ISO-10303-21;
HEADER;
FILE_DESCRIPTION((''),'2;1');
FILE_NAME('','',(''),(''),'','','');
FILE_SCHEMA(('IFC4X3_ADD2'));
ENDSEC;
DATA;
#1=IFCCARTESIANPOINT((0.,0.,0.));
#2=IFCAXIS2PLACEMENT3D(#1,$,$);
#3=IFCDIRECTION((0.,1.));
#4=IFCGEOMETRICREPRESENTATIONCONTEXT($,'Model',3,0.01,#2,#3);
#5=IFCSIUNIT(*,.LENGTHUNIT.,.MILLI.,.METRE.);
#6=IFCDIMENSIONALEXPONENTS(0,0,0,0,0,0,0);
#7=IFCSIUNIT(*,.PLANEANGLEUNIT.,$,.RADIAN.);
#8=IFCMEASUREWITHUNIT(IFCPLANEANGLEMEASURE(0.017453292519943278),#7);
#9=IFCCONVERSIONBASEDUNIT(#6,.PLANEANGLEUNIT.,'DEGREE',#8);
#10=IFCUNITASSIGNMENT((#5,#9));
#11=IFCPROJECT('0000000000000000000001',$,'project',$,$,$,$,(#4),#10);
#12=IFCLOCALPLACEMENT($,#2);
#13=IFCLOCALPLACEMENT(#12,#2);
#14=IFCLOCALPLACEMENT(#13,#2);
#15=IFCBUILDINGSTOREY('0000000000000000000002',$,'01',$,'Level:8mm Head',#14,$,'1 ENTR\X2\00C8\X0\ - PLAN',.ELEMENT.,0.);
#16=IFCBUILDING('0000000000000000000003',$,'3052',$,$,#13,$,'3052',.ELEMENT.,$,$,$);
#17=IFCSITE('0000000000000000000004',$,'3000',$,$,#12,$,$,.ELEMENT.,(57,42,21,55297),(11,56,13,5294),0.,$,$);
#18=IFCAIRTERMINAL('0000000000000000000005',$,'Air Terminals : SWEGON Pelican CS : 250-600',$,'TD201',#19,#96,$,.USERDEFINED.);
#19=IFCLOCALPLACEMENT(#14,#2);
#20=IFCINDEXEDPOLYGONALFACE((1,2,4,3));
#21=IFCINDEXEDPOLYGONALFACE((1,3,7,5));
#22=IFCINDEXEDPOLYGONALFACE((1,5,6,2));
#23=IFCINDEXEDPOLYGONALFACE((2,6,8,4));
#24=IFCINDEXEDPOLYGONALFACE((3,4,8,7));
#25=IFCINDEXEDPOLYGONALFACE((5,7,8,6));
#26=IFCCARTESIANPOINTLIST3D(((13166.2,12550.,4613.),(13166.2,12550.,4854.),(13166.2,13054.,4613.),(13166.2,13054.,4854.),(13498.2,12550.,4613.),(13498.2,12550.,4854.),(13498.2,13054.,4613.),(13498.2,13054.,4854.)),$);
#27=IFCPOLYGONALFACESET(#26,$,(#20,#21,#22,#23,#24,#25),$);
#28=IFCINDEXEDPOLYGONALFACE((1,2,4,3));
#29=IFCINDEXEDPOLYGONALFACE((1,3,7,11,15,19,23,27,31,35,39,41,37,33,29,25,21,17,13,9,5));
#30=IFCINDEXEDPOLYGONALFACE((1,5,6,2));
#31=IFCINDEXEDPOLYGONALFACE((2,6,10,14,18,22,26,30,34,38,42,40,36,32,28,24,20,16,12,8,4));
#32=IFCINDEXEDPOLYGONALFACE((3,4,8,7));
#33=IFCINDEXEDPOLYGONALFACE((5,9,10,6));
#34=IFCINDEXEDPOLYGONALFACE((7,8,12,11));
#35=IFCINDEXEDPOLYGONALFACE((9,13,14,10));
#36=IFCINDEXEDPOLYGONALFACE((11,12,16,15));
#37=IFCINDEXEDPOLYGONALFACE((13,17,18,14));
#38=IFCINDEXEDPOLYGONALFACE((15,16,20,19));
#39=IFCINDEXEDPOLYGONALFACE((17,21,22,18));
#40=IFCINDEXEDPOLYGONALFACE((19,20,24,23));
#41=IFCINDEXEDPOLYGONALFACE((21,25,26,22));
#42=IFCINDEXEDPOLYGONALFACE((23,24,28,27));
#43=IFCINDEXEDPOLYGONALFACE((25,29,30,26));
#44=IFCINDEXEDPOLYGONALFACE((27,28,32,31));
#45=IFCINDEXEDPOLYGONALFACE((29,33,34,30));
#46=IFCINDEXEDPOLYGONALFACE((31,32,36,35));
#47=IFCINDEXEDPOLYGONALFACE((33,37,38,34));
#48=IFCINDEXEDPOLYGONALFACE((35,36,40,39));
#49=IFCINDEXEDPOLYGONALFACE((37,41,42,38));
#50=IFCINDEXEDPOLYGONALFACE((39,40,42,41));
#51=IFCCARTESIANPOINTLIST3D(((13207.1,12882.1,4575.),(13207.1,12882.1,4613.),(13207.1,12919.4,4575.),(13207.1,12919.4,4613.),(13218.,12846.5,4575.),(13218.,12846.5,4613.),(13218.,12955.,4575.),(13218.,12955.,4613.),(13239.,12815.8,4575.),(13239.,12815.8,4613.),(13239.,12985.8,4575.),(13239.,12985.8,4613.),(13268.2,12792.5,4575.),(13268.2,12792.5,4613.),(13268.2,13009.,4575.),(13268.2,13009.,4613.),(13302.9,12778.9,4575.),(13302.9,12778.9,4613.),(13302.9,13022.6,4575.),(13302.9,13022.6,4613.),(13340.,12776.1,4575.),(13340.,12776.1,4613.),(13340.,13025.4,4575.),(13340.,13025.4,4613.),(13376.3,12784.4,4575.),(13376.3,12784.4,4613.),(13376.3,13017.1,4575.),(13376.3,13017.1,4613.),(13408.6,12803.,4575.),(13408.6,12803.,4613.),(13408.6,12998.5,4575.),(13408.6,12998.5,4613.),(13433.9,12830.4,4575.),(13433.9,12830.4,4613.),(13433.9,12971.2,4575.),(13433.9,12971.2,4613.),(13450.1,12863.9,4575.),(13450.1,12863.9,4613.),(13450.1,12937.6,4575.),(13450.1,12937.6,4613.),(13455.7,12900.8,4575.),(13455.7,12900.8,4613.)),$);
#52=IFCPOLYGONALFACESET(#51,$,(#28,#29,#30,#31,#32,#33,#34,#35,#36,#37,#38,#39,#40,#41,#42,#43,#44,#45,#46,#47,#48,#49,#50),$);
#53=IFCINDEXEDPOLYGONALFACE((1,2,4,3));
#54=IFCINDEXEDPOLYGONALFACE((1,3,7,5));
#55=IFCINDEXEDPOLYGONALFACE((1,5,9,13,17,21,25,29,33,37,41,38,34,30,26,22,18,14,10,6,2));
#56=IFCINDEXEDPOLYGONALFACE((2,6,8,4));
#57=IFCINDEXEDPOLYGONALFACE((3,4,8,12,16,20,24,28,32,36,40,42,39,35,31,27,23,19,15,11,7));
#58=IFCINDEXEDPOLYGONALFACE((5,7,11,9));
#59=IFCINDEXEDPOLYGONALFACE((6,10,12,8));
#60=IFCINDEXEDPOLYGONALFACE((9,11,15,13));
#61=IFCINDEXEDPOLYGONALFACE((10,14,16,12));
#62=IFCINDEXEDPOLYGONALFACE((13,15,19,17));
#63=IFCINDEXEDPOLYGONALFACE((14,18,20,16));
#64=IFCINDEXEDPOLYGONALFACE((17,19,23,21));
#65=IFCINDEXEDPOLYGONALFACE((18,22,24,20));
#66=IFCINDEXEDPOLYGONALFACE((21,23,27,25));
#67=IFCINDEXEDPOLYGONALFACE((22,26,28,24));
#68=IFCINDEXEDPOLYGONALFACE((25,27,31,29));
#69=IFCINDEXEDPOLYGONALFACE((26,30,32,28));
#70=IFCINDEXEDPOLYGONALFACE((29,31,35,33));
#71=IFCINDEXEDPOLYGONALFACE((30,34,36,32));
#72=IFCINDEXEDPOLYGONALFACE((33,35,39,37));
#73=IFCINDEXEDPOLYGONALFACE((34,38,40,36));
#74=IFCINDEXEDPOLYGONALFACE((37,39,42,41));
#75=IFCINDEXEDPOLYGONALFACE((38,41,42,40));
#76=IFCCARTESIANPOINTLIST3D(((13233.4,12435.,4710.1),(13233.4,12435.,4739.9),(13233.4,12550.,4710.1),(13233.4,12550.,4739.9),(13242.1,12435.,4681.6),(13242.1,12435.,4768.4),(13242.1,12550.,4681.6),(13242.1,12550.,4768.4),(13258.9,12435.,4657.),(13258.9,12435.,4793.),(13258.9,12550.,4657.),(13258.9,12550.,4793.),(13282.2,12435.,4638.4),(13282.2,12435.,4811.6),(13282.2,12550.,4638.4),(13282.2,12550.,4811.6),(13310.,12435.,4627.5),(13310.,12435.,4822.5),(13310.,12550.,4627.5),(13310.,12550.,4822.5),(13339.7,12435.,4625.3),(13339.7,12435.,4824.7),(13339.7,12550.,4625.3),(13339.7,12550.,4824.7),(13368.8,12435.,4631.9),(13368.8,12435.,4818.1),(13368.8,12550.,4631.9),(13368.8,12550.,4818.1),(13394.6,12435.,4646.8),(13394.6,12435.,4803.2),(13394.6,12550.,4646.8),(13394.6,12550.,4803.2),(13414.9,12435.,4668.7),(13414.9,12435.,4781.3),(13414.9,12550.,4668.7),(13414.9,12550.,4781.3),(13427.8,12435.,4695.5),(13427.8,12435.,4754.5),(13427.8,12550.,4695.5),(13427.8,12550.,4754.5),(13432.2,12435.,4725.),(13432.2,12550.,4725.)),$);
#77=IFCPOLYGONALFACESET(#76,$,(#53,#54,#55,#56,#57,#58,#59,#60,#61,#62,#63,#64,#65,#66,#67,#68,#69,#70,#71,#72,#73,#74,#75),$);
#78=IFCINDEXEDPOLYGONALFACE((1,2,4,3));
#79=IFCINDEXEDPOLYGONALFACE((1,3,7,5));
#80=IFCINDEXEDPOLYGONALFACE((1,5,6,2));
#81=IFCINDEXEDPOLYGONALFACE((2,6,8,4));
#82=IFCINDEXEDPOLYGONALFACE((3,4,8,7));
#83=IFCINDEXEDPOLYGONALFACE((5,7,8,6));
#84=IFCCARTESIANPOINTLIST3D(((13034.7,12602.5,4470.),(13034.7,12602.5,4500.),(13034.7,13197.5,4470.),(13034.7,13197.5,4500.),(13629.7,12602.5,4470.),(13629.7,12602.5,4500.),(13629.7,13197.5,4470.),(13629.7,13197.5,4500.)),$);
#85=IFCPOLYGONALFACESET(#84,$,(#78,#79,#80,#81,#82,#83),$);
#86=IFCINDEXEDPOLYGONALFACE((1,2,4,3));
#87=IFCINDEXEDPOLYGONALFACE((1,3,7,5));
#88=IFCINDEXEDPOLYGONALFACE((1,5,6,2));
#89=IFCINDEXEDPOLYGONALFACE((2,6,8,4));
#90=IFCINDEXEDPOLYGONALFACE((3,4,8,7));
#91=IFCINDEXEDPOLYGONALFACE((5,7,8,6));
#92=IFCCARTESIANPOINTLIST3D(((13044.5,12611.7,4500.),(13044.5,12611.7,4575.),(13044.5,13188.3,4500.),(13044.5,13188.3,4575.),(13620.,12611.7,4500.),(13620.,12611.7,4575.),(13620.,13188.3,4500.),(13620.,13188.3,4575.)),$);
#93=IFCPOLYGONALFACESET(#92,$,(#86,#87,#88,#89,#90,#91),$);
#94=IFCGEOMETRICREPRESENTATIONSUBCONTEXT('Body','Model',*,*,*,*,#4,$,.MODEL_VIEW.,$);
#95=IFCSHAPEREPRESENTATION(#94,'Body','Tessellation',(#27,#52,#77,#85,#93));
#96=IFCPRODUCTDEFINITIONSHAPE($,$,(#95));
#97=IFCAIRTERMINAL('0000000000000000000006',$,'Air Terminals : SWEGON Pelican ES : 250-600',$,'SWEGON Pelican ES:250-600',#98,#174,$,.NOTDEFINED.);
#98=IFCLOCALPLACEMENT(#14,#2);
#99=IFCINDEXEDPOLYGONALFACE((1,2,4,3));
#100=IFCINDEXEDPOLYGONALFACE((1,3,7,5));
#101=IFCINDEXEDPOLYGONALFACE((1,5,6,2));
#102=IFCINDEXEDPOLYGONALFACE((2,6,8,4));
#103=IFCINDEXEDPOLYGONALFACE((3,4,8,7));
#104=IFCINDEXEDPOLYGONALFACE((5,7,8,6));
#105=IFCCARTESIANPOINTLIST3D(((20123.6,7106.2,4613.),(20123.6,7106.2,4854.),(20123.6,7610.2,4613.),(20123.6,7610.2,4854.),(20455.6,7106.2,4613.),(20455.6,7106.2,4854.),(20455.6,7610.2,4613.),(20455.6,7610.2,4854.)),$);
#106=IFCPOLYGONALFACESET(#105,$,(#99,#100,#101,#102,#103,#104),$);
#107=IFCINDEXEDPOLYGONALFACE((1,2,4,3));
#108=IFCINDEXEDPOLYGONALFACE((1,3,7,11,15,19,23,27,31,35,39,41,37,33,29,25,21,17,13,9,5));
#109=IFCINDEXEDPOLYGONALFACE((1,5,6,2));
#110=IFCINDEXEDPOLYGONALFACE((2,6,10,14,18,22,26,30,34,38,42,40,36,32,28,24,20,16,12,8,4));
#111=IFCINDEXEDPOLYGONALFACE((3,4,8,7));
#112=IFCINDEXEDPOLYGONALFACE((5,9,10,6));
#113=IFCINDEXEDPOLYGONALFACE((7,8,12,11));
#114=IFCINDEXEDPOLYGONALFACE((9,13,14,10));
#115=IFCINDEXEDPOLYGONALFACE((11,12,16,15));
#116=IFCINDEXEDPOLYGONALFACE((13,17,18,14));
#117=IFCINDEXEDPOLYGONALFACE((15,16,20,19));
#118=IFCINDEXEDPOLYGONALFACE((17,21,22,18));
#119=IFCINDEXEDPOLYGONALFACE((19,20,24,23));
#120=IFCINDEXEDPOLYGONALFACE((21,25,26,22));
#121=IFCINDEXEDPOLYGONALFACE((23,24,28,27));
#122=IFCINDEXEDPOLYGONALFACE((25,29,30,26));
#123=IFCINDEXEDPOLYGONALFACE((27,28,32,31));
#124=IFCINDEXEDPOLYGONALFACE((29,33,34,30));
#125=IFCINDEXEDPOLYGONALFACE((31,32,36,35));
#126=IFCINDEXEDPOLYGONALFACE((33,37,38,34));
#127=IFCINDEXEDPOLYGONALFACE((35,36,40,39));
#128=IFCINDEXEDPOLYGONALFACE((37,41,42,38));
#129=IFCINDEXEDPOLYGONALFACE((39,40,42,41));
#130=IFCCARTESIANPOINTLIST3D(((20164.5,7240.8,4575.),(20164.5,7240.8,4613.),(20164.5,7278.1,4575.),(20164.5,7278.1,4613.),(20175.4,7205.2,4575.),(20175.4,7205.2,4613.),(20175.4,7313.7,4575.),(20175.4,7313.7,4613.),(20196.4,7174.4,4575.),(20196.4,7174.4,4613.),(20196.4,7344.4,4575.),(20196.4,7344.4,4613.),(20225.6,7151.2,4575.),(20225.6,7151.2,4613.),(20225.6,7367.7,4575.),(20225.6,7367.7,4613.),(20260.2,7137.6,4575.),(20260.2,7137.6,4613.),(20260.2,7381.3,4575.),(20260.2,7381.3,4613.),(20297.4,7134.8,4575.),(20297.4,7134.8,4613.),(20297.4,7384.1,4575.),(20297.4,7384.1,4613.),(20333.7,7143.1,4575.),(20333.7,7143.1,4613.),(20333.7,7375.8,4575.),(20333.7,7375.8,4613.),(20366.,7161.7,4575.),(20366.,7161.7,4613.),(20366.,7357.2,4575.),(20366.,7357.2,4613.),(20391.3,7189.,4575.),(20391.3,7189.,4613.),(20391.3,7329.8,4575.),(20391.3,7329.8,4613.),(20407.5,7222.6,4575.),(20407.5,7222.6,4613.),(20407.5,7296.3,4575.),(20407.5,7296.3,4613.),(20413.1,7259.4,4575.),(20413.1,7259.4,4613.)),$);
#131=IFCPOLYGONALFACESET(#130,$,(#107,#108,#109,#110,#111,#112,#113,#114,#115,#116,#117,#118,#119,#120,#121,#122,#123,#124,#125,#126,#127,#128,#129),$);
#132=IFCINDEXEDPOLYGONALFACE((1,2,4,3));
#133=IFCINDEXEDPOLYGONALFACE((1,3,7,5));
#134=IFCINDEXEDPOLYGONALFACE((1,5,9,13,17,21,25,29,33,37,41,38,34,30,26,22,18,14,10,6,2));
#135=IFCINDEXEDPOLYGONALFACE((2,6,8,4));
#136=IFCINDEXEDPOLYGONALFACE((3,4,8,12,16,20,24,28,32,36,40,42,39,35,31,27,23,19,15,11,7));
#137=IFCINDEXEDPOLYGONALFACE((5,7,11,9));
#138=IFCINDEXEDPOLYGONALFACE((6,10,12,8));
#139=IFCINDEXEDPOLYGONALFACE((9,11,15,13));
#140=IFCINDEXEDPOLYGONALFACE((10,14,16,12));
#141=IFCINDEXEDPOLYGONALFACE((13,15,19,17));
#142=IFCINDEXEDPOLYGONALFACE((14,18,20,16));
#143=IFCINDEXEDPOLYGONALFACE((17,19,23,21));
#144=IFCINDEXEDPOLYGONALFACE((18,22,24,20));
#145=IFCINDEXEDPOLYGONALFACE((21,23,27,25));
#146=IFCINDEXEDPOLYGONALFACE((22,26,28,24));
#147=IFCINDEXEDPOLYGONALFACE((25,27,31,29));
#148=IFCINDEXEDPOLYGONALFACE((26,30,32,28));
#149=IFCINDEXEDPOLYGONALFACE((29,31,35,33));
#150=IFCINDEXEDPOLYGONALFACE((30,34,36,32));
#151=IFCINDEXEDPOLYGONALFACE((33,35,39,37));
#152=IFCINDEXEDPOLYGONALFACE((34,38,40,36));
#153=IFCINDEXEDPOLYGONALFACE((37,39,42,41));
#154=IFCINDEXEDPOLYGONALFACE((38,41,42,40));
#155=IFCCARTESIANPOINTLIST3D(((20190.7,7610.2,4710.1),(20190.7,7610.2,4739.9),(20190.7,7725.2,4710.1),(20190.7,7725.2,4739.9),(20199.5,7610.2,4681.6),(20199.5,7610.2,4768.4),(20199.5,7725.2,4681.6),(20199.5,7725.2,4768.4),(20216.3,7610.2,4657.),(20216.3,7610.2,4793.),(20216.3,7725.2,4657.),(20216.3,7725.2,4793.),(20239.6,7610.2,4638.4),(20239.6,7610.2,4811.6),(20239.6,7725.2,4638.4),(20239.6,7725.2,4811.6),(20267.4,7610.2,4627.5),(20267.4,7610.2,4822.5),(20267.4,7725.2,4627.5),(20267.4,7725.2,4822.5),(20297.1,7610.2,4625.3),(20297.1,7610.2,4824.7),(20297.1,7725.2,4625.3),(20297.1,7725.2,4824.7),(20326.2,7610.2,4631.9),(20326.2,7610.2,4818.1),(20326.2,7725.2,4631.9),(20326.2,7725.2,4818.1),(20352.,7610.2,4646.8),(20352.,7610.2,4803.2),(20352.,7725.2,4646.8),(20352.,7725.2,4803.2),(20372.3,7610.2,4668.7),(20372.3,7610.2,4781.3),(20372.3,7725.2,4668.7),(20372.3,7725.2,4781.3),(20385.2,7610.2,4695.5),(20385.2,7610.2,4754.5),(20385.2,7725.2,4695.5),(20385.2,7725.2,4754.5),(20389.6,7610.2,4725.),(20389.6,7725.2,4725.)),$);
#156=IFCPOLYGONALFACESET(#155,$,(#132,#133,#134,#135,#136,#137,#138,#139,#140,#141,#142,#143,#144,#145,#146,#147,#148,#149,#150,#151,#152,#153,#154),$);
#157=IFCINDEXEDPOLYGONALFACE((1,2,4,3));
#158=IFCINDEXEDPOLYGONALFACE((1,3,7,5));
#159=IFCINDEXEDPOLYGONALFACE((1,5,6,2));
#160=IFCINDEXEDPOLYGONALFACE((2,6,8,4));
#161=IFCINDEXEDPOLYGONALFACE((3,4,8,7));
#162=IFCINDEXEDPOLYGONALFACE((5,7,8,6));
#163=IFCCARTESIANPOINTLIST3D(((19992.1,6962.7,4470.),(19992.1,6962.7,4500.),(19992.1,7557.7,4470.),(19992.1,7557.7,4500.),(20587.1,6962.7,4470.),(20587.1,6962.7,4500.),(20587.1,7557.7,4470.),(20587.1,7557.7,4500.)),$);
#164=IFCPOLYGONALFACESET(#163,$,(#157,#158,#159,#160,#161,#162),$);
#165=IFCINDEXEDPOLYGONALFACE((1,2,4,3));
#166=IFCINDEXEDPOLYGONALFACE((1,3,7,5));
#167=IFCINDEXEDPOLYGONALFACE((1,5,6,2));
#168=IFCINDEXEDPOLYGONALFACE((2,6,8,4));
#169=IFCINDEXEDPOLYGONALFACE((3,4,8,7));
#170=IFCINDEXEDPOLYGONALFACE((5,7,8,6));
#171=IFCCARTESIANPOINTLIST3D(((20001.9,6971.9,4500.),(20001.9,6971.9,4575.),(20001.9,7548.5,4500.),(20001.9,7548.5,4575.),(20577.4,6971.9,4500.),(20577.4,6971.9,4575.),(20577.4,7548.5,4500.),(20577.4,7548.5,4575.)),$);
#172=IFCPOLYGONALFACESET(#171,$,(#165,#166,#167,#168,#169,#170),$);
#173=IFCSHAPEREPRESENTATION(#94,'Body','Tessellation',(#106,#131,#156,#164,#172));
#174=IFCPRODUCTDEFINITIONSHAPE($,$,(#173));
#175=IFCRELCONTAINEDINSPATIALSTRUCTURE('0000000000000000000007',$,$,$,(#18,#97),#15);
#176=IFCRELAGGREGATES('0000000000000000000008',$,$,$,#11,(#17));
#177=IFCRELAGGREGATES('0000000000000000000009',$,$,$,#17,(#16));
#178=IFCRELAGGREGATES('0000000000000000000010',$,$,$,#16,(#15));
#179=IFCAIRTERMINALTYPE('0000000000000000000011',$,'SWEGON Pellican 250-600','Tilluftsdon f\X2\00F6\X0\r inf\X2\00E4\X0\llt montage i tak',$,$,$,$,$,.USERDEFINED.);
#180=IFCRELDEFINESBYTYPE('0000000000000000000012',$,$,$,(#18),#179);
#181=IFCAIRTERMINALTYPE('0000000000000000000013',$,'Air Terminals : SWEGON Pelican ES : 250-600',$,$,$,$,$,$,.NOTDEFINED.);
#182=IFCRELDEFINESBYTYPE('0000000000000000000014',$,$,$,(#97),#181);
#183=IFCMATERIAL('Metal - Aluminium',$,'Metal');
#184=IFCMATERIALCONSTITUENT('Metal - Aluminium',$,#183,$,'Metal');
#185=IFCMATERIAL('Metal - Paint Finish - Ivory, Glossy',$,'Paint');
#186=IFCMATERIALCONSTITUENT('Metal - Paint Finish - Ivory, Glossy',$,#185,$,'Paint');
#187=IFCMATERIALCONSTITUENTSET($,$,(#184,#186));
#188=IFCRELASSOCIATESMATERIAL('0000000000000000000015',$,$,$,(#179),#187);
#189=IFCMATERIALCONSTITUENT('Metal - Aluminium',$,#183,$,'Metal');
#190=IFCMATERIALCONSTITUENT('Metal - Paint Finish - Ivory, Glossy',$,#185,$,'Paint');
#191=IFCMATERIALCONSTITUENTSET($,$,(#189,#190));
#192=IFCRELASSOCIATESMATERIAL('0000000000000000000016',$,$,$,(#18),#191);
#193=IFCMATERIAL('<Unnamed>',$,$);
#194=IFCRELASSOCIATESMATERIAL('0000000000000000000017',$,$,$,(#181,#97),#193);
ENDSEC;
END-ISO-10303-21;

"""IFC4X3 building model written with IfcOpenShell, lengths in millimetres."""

from ifc_helpers import new_model, entity, si_unit, converted_unit, direction, frame, frame_2d, origin, origin_2d_with_axis, place, context, subcontext, project, spatial, rectangle, circle, extrude, source, transform, mapped, material, constituent, constituent_set, type_object, type_shapes, element, save


model = new_model("IFC4X3")

# Units and contexts
model_context = context("Model", 3, precision=0.01, world=origin(), true_north=direction((0.0, 1.0)))
body_context = subcontext(model_context, "Body", "Model", "MODEL_VIEW")
ifc_project = project(units=[si_unit("LENGTHUNIT", "METRE", prefix="MILLI"), converted_unit("PLANEANGLEUNIT", "DEGREE", entity("IfcPlaneAngleMeasure", 0.017453292519943278), si_unit("PLANEANGLEUNIT", "RADIAN"), dimensions=[0, 0, 0, 0, 0, 0, 0])], contexts=[model_context])

# Site, building, storey
site_placement = place(None, origin())
site = spatial("IfcSite", under=ifc_project, at=site_placement, Name="3000", CompositionType="ELEMENT", RefLatitude=(57, 42, 21, 55297), RefLongitude=(11, 56, 13, 5294), RefElevation=0.0)
building_placement = place(site_placement, origin())
building = spatial("IfcBuilding", under=site, at=building_placement, Name="3052", LongName="3052", CompositionType="ELEMENT")
storey_placement = place(building_placement, origin())
storey = spatial("IfcBuildingStorey", under=building, at=storey_placement, Name="01", ObjectType="Level:8mm Head", LongName="1 ENTRÈ - PLAN", CompositionType="ELEMENT", Elevation=0.0)

# Shared definitions
ifc_material_1 = material(Name="Metal - Aluminium", Category="Metal")
ifc_material_2 = material(Name="Metal - Paint Finish - Ivory, Glossy", Category="Paint")
ifc_material_3 = material(Name="<Unnamed>")

# Air terminals
ifc_constituent_1 = constituent(ifc_material_1, Name="Metal - Aluminium", Category="Metal")
ifc_constituent_2 = constituent(ifc_material_2, Name="Metal - Paint Finish - Ivory, Glossy", Category="Paint")
ifc_constituent_set_1 = constituent_set(constituents=[ifc_constituent_1, ifc_constituent_2])
air_terminal_type_1 = type_object("IfcAirTerminalType", Name="SWEGON Pellican 250-600", Description="Tilluftsdon för infällt montage i tak", PredefinedType="USERDEFINED", material=ifc_constituent_set_1)
shared_shape_1 = source(origin(), body_context, "Body", "SweptSolid", [
    extrude(rectangle(XDim=332.0, YDim=504.0, at=origin_2d_with_axis()), frame((0.0, 98.0, -354.0), z_axis=(0.0, 0.0, 1.0), x_axis=(-1.0, 0.0, 0.0)), (0.0, 0.0, 1.0), 241.0),
    extrude(circle(Radius=125.0, at=frame_2d((0.0, 0.0), x_axis=(1.0, 0.0))), frame((-1.6, -0.8, -113.0)), (0.0, 0.0, 1.0), 38.0),
    extrude(circle(Radius=100.0, at=frame_2d((0.0, 0.0), x_axis=(1.0, 0.0))), frame((0.0, 350.0, -225.0), z_axis=(0.0, 1.0, 0.0), x_axis=(1.0, 0.0, 0.0)), (0.0, 0.0, 1.0), 115.0),
    extrude(rectangle(XDim=595.0, YDim=595.0, at=frame_2d((0.0, 0.0), x_axis=(1.0, 0.0))), frame((0.0, 0.0, 0.0), z_axis=(0.0, 0.0, 1.0), x_axis=(-1.0, 0.0, 0.0)), (0.0, 0.0, 1.0), 30.0),
    extrude(rectangle(XDim=575.5, YDim=576.5, at=origin_2d_with_axis()), frame((0.0, 0.0, -75.0), z_axis=(0.0, 0.0, 1.0), x_axis=(-1.0, 0.0, 0.0)), (0.0, 0.0, 1.0), 75.0),
])
type_shapes(air_terminal_type_1, [shared_shape_1])
ifc_constituent_3 = constituent(ifc_material_1, Name="Metal - Aluminium", Category="Metal")
ifc_constituent_4 = constituent(ifc_material_2, Name="Metal - Paint Finish - Ivory, Glossy", Category="Paint")
ifc_constituent_set_2 = constituent_set(constituents=[ifc_constituent_3, ifc_constituent_4])
air_terminal_1_placement = place(storey_placement, frame((13332.2, 12900.0, 4500.0), z_axis=(0.0, 0.0, -1.0), x_axis=(1.0, 0.0, 0.0)))
element("IfcAirTerminal", 1, at=air_terminal_1_placement, inside=storey, type_object=air_terminal_type_1, material=ifc_constituent_set_2, Name="Air Terminals : SWEGON Pelican CS : 250-600", ObjectType="TD201", PredefinedType="USERDEFINED", context=body_context, shape_type="MappedRepresentation", body=[
    mapped(shared_shape_1, transform((0.0, 0.0, 0.0), scale=1.0)),
])
air_terminal_type_2 = type_object("IfcAirTerminalType", Name="Air Terminals : SWEGON Pelican ES : 250-600", PredefinedType="NOTDEFINED", material=ifc_material_3)
shared_shape_2 = source(origin(), body_context, "Body", "SweptSolid", [
    extrude(rectangle(XDim=504.0, YDim=332.0, at=origin_2d_with_axis()), frame((0.0, -98.0, -354.0), z_axis=(0.0, 0.0, 1.0), x_axis=(0.0, 1.0, 0.0)), (0.0, 0.0, 1.0), 241.0),
    extrude(circle(Radius=125.0, at=frame_2d((0.0, 0.0), x_axis=(1.0, 0.0))), frame((-1.6, 0.8, -113.0)), (0.0, 0.0, 1.0), 38.0),
    extrude(circle(Radius=100.0, at=frame_2d((0.0, 0.0), x_axis=(1.0, 0.0))), frame((0.0, -465.0, -225.0), z_axis=(0.0, 1.0, 0.0), x_axis=(1.0, 0.0, 0.0)), (0.0, 0.0, 1.0), 115.0),
    extrude(rectangle(XDim=595.0, YDim=595.0, at=frame_2d((0.0, 0.0), x_axis=(1.0, 0.0))), frame((0.0, 0.0, 0.0), z_axis=(0.0, 0.0, 1.0), x_axis=(0.0, 1.0, 0.0)), (0.0, 0.0, 1.0), 30.0),
    extrude(rectangle(XDim=576.5, YDim=575.5, at=origin_2d_with_axis()), frame((0.0, 0.0, -75.0), z_axis=(0.0, 0.0, 1.0), x_axis=(0.0, 1.0, 0.0)), (0.0, 0.0, 1.0), 75.0),
])
type_shapes(air_terminal_type_2, [shared_shape_2])
air_terminal_2_placement = place(storey_placement, frame((20289.6, 7260.2, 4500.0), z_axis=(0.0, 0.0, -1.0), x_axis=(1.0, 0.0, 0.0)))
element("IfcAirTerminal", 2, at=air_terminal_2_placement, inside=storey, type_object=air_terminal_type_2, material=ifc_material_3, Name="Air Terminals : SWEGON Pelican ES : 250-600", ObjectType="SWEGON Pelican ES:250-600", PredefinedType="NOTDEFINED", context=body_context, shape_type="MappedRepresentation", body=[
    mapped(shared_shape_2, transform((0.0, 0.0, 0.0), scale=1.0)),
])

save(model, "model.ifc")
